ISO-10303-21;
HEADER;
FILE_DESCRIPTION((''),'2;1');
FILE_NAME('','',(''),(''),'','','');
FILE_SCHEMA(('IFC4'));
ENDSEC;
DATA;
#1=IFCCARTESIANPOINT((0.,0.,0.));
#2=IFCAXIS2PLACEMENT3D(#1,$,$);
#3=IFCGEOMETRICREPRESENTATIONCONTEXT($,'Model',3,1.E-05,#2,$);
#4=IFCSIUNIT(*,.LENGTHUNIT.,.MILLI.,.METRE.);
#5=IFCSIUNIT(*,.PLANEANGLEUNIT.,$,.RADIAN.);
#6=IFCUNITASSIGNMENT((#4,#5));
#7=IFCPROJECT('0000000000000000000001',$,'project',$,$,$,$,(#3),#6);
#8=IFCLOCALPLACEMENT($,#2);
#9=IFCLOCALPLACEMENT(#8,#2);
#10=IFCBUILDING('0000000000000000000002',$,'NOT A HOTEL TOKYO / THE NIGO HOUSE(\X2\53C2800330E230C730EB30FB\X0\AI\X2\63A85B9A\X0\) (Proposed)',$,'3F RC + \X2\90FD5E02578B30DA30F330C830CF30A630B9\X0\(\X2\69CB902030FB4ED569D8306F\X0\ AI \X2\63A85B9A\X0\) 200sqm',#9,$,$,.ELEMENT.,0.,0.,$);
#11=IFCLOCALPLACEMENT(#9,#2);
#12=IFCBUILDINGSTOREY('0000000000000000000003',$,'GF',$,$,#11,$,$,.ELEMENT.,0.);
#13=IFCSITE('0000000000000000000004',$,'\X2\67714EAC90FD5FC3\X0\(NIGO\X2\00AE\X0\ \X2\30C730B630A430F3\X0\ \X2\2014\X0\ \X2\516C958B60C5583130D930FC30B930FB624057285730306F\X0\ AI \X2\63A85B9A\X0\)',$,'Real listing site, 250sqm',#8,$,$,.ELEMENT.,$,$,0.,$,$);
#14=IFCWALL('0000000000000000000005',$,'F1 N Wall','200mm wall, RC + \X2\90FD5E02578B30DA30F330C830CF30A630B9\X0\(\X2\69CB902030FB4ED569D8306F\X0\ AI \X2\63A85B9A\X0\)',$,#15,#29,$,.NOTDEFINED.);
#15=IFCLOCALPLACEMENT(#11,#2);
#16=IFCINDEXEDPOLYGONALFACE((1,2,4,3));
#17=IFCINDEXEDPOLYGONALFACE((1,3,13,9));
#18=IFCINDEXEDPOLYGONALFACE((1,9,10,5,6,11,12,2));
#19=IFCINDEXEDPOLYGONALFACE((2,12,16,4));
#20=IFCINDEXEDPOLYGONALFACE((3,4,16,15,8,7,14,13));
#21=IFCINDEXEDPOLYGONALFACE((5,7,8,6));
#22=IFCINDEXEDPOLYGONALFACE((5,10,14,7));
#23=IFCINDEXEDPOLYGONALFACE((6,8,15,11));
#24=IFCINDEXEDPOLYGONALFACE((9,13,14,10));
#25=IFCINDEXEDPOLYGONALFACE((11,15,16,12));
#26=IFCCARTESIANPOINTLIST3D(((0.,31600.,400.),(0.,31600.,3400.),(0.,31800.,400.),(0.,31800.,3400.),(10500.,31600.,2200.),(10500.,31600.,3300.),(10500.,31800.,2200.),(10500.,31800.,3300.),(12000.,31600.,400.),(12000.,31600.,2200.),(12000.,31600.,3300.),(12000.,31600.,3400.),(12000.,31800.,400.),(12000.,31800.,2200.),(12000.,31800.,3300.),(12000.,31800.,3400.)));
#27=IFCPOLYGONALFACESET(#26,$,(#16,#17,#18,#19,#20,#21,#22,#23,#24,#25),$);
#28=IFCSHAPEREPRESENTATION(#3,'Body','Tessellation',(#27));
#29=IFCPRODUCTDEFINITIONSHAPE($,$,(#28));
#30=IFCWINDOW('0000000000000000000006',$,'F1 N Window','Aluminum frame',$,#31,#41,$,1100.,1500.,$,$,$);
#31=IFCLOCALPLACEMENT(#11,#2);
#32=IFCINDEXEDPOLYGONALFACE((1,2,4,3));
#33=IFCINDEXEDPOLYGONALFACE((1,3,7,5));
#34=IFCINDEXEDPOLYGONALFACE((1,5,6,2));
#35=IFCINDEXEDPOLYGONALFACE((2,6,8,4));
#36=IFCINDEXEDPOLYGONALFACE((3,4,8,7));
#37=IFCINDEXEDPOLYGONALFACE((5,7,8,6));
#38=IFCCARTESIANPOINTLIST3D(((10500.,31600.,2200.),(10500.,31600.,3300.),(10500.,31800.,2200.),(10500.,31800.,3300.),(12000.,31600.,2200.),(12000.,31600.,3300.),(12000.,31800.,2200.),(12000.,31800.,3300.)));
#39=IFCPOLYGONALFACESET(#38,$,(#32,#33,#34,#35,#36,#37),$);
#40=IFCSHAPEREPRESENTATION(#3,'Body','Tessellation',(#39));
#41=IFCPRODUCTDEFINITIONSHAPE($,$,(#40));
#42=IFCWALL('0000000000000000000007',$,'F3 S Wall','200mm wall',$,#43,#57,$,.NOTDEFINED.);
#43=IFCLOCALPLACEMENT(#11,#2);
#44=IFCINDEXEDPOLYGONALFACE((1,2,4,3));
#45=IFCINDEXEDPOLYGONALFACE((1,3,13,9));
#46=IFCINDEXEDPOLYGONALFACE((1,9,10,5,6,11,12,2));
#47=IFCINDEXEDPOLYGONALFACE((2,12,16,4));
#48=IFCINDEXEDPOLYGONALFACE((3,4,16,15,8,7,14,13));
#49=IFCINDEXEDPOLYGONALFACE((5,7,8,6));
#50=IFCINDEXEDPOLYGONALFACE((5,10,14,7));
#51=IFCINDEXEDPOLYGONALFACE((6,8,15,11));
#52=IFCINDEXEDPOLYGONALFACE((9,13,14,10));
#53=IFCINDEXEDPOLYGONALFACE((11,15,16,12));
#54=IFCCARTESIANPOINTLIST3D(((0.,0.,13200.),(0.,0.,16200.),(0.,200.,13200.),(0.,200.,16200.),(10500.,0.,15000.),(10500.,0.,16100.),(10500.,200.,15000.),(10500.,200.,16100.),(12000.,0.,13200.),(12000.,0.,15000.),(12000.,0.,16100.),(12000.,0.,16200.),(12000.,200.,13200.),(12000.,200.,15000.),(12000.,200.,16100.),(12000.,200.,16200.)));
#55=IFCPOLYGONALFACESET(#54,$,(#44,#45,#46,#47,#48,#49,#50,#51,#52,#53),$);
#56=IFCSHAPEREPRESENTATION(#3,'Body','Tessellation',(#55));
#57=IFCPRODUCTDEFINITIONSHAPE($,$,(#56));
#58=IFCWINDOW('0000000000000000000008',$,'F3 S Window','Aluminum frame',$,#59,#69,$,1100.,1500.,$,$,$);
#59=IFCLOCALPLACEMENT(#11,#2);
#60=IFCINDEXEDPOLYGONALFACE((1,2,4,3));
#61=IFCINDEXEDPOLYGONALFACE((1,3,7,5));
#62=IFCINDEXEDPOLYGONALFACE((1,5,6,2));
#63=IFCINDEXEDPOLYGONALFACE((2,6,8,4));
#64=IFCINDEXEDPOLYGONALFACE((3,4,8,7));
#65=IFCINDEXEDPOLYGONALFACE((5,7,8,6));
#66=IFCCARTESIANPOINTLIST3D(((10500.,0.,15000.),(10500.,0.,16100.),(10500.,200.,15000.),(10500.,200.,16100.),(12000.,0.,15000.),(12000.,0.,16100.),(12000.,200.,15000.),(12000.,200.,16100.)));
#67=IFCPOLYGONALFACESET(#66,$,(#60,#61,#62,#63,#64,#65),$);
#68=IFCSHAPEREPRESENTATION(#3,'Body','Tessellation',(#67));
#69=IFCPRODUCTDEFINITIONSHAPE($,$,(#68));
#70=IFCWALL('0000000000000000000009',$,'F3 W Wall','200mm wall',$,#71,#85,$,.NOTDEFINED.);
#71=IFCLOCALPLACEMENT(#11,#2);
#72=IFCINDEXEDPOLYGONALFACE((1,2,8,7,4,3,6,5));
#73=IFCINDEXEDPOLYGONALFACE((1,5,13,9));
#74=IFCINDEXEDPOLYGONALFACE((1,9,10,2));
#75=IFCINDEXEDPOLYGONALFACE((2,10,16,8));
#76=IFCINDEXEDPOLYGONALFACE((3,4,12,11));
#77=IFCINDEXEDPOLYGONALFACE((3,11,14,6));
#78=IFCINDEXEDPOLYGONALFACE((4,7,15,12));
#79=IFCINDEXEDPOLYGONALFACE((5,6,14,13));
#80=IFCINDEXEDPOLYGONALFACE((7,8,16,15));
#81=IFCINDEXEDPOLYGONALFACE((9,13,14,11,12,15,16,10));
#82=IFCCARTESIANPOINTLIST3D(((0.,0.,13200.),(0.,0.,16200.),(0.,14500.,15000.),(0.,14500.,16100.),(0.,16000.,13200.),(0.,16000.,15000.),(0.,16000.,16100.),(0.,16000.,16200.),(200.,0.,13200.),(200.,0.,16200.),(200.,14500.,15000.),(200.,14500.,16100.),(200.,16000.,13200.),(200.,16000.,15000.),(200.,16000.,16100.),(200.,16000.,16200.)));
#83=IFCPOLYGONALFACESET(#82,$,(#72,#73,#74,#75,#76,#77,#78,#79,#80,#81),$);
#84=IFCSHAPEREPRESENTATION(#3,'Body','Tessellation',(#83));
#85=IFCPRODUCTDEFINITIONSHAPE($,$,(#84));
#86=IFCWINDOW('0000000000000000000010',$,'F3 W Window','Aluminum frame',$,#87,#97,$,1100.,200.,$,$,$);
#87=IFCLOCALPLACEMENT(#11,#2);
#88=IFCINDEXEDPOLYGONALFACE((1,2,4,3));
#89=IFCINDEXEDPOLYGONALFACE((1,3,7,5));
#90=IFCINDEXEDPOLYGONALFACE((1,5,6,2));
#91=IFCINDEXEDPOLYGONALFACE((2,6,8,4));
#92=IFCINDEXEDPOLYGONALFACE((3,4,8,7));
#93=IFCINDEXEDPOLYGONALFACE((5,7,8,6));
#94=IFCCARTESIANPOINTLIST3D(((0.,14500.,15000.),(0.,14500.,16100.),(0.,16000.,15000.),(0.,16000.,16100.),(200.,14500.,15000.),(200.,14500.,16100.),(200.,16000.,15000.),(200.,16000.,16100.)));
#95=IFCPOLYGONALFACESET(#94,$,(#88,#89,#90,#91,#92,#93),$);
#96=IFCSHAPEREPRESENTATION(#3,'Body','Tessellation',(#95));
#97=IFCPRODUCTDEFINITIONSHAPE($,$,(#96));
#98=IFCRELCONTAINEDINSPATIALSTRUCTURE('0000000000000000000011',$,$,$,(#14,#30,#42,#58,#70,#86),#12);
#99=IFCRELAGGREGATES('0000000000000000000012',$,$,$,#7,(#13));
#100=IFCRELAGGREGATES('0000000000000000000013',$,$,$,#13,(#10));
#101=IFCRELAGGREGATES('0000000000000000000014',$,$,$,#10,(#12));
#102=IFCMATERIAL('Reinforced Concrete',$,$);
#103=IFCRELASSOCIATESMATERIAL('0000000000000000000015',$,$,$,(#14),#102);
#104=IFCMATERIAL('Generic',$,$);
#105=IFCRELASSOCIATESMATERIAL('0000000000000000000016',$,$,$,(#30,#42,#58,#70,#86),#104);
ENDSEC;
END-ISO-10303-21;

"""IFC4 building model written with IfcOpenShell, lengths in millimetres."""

from ifc_helpers import new_model, si_unit, frame, frame_2d, origin, place, context, project, spatial, rectangle, extrude, material, element, fill, save


model = new_model("IFC4")

# Units and contexts
model_context = context("Model", 3, precision=1e-05, world=origin())
ifc_project = project(units=[si_unit("LENGTHUNIT", "METRE", prefix="MILLI"), si_unit("PLANEANGLEUNIT", "RADIAN")], contexts=[model_context])

# Site, building, storey
site_placement = place(None, origin())
site = spatial("IfcSite", under=ifc_project, at=site_placement, Name="東京都心(NIGO® デザイン — 公開情報ベース・所在地は AI 推定)", ObjectType="Real listing site, 250sqm", CompositionType="ELEMENT", RefElevation=0.0)
building_placement = place(site_placement, origin())
building = spatial("IfcBuilding", under=site, at=building_placement, Name="NOT A HOTEL TOKYO / THE NIGO HOUSE(参考モデル・AI推定) (Proposed)", ObjectType="3F RC + 都市型ペントハウス(構造・仕様は AI 推定) 200sqm", CompositionType="ELEMENT", ElevationOfRefHeight=0.0, ElevationOfTerrain=0.0)
storey_placement = place(building_placement, origin())
storey = spatial("IfcBuildingStorey", under=building, at=storey_placement, Name="GF", CompositionType="ELEMENT", Elevation=0.0)

# Shared definitions
ifc_material_1 = material(Name="Reinforced Concrete")

# Walls, openings, windows
wall_1_placement = place(storey_placement, frame((0.0, 15800.0, 200.0)))
wall_1 = element("IfcWall", 1, at=wall_1_placement, inside=storey, material=ifc_material_1, Name="F1 N Wall", Description="200mm wall, RC + 都市型ペントハウス(構造・仕様は AI 推定)", PredefinedType="NOTDEFINED", context=model_context, shape_type="SweptSolid", body=[
    extrude(rectangle(XDim=12000.0, YDim=200.0, at=frame_2d((6000.0, 100.0))), frame((0.0, 15800.0, 200.0)), (0.0, 0.0, 1.0), 3000.0),
])
opening_1_placement = place(storey_placement, frame((5250.0, 15800.0, 1100.0)))
opening_1 = element("IfcOpeningElement", 2, at=opening_1_placement, cuts=wall_1, PredefinedType="NOTDEFINED", context=model_context, shape_type="SweptSolid", body=[
    extrude(rectangle(XDim=1500.0, YDim=200.0, at=frame_2d((750.0, 100.0))), frame((5250.0, 15800.0, 1100.0)), (0.0, 0.0, 1.0), 1100.0),
])
ifc_material_2 = material(Name="Generic")
window_1_placement = place(storey_placement, frame((5250.0, 15800.0, 1100.0)))
window_1 = element("IfcWindow", 3, at=window_1_placement, inside=storey, material=ifc_material_2, Name="F1 N Window", Description="Aluminum frame", OverallHeight=1100.0, OverallWidth=1500.0, context=model_context, shape_type="SweptSolid", body=[
    extrude(rectangle(XDim=1500.0, YDim=200.0, at=frame_2d((750.0, 100.0))), frame((5250.0, 15800.0, 1100.0)), (0.0, 0.0, 1.0), 1100.0),
])
fill(opening_1, window_1)
wall_2_placement = place(storey_placement, frame((0.0, 0.0, 6600.0)))
wall_2 = element("IfcWall", 4, at=wall_2_placement, inside=storey, material=ifc_material_2, Name="F3 S Wall", Description="200mm wall", PredefinedType="NOTDEFINED", context=model_context, shape_type="SweptSolid", body=[
    extrude(rectangle(XDim=12000.0, YDim=200.0, at=frame_2d((6000.0, 100.0))), frame((0.0, 0.0, 6600.0)), (0.0, 0.0, 1.0), 3000.0),
])
opening_2_placement = place(storey_placement, frame((5250.0, 0.0, 7500.0)))
opening_2 = element("IfcOpeningElement", 5, at=opening_2_placement, cuts=wall_2, PredefinedType="NOTDEFINED", context=model_context, shape_type="SweptSolid", body=[
    extrude(rectangle(XDim=1500.0, YDim=200.0, at=frame_2d((750.0, 100.0))), frame((5250.0, 0.0, 7500.0)), (0.0, 0.0, 1.0), 1100.0),
])
window_2_placement = place(storey_placement, frame((5250.0, 0.0, 7500.0)))
window_2 = element("IfcWindow", 6, at=window_2_placement, inside=storey, material=ifc_material_2, Name="F3 S Window", Description="Aluminum frame", OverallHeight=1100.0, OverallWidth=1500.0, context=model_context, shape_type="SweptSolid", body=[
    extrude(rectangle(XDim=1500.0, YDim=200.0, at=frame_2d((750.0, 100.0))), frame((5250.0, 0.0, 7500.0)), (0.0, 0.0, 1.0), 1100.0),
])
fill(opening_2, window_2)
wall_3_placement = place(storey_placement, frame((0.0, 0.0, 6600.0)))
wall_3 = element("IfcWall", 7, at=wall_3_placement, inside=storey, material=ifc_material_2, Name="F3 W Wall", Description="200mm wall", PredefinedType="NOTDEFINED", context=model_context, shape_type="SweptSolid", body=[
    extrude(rectangle(XDim=200.0, YDim=16000.0, at=frame_2d((100.0, 8000.0))), frame((0.0, 0.0, 6600.0)), (0.0, 0.0, 1.0), 3000.0),
])
opening_3_placement = place(storey_placement, frame((0.0, 7250.0, 7500.0)))
opening_3 = element("IfcOpeningElement", 8, at=opening_3_placement, cuts=wall_3, PredefinedType="NOTDEFINED", context=model_context, shape_type="SweptSolid", body=[
    extrude(rectangle(XDim=200.0, YDim=1500.0, at=frame_2d((100.0, 750.0))), frame((0.0, 7250.0, 7500.0)), (0.0, 0.0, 1.0), 1100.0),
])
window_3_placement = place(storey_placement, frame((0.0, 7250.0, 7500.0)))
window_3 = element("IfcWindow", 9, at=window_3_placement, inside=storey, material=ifc_material_2, Name="F3 W Window", Description="Aluminum frame", OverallHeight=1100.0, OverallWidth=200.0, context=model_context, shape_type="SweptSolid", body=[
    extrude(rectangle(XDim=200.0, YDim=1500.0, at=frame_2d((100.0, 750.0))), frame((0.0, 7250.0, 7500.0)), (0.0, 0.0, 1.0), 1100.0),
])
fill(opening_3, window_3)

save(model, "model.ifc")
